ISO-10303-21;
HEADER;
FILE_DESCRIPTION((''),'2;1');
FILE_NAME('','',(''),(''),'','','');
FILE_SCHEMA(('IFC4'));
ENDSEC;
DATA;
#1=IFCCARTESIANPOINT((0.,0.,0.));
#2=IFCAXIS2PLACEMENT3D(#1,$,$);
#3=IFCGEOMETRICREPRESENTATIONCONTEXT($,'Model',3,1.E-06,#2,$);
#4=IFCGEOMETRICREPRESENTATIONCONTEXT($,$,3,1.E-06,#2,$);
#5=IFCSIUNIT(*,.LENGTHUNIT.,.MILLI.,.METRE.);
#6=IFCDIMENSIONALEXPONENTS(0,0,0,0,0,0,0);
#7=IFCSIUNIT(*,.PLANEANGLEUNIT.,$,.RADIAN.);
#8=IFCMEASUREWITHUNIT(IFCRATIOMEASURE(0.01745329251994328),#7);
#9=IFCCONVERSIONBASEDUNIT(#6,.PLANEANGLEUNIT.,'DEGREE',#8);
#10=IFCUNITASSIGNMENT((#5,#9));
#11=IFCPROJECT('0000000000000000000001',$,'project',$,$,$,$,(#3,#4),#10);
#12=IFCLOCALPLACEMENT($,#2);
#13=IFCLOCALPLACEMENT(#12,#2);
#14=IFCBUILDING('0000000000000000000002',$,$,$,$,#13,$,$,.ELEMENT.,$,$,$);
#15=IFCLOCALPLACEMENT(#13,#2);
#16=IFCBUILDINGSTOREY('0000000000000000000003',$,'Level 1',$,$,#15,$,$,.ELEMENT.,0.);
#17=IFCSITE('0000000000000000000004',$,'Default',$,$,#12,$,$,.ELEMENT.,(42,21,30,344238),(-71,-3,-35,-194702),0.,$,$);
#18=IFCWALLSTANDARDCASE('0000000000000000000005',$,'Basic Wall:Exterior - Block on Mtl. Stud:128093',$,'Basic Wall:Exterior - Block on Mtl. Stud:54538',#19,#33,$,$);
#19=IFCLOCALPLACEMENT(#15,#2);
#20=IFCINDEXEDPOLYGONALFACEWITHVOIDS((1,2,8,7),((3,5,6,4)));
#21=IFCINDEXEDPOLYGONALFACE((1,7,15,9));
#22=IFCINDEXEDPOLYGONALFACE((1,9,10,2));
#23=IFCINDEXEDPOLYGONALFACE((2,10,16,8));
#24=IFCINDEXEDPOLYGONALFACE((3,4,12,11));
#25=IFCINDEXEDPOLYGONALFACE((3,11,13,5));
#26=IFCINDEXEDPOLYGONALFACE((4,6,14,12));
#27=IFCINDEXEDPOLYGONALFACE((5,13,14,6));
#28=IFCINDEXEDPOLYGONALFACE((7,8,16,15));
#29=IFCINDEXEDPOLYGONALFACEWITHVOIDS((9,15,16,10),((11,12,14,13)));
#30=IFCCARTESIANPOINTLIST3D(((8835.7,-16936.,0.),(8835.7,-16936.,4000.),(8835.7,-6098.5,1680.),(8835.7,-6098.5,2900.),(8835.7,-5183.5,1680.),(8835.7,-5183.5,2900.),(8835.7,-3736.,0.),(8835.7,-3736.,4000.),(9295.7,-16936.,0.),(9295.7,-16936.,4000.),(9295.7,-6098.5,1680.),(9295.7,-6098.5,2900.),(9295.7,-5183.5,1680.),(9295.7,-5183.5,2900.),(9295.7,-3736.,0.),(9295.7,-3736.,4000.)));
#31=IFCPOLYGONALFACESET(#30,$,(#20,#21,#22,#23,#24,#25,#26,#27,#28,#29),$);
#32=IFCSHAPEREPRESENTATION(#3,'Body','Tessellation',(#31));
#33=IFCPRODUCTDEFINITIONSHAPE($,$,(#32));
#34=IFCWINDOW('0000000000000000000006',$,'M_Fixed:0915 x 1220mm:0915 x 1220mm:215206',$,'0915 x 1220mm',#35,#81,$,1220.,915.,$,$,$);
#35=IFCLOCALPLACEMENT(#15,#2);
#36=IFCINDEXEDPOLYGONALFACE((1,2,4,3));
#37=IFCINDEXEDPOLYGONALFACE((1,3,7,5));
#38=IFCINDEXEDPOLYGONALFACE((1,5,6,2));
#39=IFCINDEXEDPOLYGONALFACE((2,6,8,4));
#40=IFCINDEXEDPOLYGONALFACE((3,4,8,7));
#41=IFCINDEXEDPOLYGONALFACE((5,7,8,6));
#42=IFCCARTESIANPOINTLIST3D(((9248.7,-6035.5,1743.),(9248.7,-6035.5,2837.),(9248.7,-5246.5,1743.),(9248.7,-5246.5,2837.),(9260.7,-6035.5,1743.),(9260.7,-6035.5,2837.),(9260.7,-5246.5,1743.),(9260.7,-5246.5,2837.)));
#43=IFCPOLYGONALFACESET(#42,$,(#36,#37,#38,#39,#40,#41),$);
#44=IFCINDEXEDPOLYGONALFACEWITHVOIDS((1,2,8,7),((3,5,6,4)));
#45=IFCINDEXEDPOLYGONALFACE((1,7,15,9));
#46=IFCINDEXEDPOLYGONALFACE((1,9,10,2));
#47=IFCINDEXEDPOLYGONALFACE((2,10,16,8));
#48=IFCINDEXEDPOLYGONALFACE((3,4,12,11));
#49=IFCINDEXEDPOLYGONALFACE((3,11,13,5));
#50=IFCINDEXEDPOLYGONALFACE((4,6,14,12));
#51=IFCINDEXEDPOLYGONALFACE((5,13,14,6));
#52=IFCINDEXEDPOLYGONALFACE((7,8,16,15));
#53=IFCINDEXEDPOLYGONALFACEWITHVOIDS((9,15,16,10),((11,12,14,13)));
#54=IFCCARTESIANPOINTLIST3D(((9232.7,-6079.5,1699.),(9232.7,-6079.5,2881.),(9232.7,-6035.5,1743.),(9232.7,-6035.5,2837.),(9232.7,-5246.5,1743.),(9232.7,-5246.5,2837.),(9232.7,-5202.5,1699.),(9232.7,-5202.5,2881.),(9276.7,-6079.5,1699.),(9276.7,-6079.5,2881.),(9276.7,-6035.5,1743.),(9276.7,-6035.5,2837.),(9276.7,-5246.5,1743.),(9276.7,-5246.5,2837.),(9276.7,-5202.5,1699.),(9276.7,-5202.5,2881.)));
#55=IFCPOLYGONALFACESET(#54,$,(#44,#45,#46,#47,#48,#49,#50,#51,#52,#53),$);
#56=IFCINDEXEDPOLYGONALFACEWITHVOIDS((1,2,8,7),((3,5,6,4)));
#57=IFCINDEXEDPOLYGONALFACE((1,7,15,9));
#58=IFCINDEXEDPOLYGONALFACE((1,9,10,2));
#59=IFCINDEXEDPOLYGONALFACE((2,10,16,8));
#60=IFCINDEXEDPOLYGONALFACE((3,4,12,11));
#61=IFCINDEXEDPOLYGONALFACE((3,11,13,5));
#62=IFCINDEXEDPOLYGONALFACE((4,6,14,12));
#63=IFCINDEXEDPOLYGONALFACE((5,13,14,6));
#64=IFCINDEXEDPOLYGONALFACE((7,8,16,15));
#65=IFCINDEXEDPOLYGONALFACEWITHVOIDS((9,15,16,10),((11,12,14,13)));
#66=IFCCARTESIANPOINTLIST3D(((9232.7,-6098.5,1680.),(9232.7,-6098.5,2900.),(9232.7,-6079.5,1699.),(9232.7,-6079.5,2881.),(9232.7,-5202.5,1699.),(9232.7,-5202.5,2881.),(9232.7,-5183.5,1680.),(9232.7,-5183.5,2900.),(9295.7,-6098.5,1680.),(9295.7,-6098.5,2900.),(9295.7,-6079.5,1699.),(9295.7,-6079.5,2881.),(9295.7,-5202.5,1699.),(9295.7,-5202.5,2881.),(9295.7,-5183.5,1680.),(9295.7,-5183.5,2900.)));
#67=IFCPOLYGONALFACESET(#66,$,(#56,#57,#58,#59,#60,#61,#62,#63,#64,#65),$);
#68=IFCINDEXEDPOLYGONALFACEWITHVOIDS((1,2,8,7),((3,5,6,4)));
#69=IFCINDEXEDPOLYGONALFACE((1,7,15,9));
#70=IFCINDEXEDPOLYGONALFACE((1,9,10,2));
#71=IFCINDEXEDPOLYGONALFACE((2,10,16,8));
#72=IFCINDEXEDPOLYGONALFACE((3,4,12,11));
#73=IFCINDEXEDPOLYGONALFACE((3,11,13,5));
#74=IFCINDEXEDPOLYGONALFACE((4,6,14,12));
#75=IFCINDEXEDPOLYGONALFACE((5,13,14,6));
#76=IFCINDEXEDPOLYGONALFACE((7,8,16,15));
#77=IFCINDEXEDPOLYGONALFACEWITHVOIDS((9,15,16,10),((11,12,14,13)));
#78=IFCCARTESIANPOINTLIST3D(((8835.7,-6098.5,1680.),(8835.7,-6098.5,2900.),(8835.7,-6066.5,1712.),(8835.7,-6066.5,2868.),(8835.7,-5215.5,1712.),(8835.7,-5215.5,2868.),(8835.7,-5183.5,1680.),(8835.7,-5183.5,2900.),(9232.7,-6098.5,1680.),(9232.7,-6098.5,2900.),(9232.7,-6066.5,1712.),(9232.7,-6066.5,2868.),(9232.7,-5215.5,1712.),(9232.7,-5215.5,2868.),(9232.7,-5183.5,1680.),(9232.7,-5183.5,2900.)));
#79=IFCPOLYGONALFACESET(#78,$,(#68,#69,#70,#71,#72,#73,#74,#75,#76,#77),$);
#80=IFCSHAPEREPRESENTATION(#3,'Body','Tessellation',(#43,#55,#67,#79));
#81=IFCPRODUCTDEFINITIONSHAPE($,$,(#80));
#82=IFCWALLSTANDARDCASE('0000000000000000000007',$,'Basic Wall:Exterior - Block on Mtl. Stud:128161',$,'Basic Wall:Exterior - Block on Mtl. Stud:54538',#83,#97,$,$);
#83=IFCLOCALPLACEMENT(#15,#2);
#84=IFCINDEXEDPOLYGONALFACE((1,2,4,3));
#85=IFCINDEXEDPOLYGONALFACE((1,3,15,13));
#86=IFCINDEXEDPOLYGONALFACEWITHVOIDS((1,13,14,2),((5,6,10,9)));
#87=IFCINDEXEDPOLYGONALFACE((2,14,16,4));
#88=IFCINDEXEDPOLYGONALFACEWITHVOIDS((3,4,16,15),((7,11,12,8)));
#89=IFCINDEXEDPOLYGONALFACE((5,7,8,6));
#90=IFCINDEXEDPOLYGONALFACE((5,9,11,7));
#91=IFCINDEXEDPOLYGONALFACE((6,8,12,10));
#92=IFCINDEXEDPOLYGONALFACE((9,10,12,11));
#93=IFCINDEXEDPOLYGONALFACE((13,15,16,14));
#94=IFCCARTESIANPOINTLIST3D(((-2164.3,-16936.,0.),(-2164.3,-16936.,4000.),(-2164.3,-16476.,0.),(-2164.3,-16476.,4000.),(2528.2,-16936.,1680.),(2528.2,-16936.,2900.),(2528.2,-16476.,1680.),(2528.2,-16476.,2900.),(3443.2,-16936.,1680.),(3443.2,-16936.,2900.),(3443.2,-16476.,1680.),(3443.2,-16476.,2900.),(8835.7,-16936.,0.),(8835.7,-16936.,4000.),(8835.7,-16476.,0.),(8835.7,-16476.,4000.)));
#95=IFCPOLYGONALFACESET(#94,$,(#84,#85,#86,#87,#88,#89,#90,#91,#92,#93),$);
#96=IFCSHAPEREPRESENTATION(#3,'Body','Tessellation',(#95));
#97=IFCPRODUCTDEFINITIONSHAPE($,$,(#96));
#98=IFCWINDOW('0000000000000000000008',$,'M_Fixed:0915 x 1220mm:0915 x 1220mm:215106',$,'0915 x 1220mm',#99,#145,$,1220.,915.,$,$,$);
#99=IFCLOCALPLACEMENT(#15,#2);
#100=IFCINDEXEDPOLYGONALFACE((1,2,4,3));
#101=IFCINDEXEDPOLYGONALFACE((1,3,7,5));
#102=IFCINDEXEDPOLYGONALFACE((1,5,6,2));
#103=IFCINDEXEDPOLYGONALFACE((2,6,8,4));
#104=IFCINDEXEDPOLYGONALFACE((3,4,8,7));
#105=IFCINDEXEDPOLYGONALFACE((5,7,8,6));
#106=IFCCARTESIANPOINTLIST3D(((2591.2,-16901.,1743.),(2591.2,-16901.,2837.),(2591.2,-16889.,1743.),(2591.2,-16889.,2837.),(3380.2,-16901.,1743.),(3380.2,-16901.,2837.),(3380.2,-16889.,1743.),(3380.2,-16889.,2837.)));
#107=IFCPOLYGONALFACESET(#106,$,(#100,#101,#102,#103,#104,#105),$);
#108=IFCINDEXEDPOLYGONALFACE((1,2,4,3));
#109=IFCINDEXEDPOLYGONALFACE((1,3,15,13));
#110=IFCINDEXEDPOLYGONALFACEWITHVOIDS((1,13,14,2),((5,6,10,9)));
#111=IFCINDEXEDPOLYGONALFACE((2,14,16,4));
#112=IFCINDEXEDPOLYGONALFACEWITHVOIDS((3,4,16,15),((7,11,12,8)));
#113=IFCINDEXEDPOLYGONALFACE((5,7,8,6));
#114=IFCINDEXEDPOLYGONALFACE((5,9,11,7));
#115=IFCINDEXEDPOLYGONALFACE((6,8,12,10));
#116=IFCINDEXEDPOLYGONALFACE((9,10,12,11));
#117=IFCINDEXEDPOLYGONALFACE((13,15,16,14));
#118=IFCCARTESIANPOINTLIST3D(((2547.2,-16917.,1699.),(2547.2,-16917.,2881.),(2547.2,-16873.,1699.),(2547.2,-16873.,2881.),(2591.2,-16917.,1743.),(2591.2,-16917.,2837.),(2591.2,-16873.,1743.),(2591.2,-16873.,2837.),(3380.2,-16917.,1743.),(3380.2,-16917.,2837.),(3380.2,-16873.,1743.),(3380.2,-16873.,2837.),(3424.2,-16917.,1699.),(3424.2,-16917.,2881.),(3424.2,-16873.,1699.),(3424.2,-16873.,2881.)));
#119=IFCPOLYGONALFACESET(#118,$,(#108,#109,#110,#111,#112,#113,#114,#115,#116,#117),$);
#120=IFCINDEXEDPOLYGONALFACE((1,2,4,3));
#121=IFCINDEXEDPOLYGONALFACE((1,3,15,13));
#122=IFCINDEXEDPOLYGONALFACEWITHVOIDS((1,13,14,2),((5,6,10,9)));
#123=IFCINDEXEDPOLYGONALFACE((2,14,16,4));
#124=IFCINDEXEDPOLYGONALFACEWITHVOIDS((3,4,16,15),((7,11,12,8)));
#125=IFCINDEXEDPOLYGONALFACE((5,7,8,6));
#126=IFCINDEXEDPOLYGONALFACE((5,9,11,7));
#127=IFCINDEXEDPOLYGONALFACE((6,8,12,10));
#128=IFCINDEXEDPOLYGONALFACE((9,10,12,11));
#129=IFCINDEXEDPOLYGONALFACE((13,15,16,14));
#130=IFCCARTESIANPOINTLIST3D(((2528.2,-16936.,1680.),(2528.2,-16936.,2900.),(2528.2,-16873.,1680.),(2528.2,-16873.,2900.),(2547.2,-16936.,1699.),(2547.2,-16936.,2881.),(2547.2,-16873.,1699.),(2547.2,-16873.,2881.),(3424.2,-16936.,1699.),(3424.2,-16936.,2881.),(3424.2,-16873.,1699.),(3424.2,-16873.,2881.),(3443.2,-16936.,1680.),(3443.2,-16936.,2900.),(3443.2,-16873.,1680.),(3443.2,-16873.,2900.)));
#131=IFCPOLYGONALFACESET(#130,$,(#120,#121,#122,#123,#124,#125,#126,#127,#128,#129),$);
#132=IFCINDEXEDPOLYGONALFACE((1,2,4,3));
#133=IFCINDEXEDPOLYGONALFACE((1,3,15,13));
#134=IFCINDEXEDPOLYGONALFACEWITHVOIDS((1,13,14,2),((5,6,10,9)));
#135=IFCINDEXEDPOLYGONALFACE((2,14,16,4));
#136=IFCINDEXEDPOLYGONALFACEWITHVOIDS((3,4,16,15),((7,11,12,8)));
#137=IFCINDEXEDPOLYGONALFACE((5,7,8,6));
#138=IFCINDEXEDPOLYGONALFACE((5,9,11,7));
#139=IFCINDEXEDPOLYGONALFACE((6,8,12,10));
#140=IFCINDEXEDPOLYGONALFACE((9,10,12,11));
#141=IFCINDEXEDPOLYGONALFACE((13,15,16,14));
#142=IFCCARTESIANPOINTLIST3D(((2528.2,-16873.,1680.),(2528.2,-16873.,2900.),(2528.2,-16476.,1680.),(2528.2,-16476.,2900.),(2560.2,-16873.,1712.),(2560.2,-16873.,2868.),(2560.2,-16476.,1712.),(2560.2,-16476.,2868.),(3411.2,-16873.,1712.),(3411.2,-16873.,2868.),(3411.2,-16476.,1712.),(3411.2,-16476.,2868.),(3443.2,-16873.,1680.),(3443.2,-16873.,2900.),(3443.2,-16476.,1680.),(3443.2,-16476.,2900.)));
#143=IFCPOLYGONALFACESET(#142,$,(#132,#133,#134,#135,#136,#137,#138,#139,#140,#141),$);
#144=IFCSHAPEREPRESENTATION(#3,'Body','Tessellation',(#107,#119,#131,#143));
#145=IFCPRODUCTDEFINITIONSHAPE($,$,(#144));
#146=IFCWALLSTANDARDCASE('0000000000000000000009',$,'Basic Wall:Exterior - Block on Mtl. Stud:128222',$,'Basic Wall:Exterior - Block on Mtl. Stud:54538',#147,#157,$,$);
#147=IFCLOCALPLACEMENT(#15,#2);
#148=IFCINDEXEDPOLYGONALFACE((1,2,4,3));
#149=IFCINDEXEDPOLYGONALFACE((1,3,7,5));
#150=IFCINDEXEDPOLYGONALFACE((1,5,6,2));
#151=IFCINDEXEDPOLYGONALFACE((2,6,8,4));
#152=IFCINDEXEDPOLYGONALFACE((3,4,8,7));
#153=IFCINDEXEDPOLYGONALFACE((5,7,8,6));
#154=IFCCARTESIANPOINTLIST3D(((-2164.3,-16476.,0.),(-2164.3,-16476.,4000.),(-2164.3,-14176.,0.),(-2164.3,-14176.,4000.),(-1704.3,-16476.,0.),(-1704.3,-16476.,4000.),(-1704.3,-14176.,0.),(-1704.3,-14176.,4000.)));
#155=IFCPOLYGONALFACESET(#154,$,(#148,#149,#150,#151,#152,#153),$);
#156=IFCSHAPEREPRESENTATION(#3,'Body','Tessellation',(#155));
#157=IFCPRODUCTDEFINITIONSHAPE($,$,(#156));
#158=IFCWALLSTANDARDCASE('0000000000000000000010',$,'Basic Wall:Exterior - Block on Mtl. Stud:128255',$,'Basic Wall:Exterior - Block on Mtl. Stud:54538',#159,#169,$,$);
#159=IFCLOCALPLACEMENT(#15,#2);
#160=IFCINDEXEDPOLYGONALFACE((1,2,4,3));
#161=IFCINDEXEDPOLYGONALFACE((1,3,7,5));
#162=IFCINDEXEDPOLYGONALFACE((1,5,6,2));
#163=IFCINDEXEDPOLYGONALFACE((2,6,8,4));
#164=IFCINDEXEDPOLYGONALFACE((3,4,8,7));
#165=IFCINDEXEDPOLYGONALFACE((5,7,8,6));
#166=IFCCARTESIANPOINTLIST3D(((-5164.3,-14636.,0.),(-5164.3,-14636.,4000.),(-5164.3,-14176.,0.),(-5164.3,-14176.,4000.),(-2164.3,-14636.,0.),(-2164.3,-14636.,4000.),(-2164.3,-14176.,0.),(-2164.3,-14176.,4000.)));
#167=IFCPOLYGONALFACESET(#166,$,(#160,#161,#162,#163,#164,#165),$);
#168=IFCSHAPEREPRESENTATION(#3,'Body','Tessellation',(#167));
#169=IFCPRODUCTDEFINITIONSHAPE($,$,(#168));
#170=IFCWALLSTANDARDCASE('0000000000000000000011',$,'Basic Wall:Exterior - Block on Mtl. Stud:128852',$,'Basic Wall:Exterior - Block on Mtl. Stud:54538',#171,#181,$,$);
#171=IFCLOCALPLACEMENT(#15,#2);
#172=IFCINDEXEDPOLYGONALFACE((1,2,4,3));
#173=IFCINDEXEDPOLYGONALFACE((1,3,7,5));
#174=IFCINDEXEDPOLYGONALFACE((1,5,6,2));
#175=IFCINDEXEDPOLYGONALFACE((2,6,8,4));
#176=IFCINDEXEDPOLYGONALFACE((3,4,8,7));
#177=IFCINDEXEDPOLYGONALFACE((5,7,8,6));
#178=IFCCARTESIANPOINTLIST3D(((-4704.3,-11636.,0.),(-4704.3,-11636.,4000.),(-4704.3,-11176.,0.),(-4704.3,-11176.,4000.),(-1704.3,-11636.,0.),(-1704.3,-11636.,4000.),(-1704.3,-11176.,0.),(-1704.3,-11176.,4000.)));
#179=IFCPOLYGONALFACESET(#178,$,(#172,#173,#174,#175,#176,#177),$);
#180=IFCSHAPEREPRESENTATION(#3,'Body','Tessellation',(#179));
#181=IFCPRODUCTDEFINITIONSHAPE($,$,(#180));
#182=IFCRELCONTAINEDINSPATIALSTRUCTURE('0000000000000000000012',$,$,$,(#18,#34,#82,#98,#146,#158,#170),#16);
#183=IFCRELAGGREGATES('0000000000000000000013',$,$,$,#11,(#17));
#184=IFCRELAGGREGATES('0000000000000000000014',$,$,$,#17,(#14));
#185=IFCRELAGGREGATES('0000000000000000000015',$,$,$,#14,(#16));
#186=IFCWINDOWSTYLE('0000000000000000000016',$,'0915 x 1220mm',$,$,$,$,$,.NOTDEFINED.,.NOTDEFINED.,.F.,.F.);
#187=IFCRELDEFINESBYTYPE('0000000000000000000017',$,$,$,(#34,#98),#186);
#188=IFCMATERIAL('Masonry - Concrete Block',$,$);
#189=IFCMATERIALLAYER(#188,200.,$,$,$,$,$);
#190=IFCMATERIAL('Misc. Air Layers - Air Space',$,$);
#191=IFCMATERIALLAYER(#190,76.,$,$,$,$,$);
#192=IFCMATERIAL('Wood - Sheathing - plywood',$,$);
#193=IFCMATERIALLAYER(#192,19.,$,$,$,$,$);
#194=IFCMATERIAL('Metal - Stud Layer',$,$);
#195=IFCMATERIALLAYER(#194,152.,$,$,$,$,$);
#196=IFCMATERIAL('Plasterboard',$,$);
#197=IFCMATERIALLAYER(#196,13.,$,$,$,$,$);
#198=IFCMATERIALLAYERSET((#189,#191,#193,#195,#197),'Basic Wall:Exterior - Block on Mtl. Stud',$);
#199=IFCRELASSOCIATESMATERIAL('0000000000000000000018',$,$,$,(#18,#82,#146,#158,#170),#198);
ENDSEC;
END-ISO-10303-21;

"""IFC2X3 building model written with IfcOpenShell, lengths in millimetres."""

from ifc_helpers import new_model, entity, si_unit, converted_unit, frame, frame_2d, origin, origin_2d_with_axis, place, context, project, spatial, polyline, rectangle, outline, extrude, source, transform, mapped, material, layer, layer_set, layer_usage, type_object, type_shapes, element, fill, save


model = new_model("IFC2X3")

# Units and contexts
model_context = context("Model", 3, precision=1e-06, world=origin())
context_of_model = context(None, 3, precision=1e-06, world=origin())
ifc_project = project(units=[si_unit("LENGTHUNIT", "METRE", prefix="MILLI"), converted_unit("PLANEANGLEUNIT", "DEGREE", entity("IfcRatioMeasure", 0.01745329251994328), si_unit("PLANEANGLEUNIT", "RADIAN"), dimensions=[0, 0, 0, 0, 0, 0, 0])], contexts=[model_context, context_of_model])

# Site, building, storey
site_placement = place(None, origin())
site = spatial("IfcSite", under=ifc_project, at=site_placement, Name="Default", CompositionType="ELEMENT", RefLatitude=(42, 21, 30, 344238), RefLongitude=(-71, -3, -35, -194702), RefElevation=0.0)
building_placement = place(site_placement, origin())
building = spatial("IfcBuilding", under=site, at=building_placement, CompositionType="ELEMENT")
storey_placement = place(building_placement, origin())
storey = spatial("IfcBuildingStorey", under=building, at=storey_placement, Name="Level 1", CompositionType="ELEMENT", Elevation=0.0)

# Walls, openings, windows
ifc_material_1 = material(Name="Masonry - Concrete Block")
ifc_layer_1 = layer(ifc_material_1, 200.0)
ifc_material_2 = material(Name="Misc. Air Layers - Air Space")
ifc_layer_2 = layer(ifc_material_2, 76.0)
ifc_material_3 = material(Name="Wood - Sheathing - plywood")
ifc_layer_3 = layer(ifc_material_3, 19.0)
ifc_material_4 = material(Name="Metal - Stud Layer")
ifc_layer_4 = layer(ifc_material_4, 152.0)
ifc_material_5 = material(Name="Plasterboard")
ifc_layer_5 = layer(ifc_material_5, 13.0)
ifc_layer_set_1 = layer_set([ifc_layer_1, ifc_layer_2, ifc_layer_3, ifc_layer_4, ifc_layer_5], Name="Basic Wall:Exterior - Block on Mtl. Stud")
ifc_layer_usage_1 = layer_usage(ifc_layer_set_1, "AXIS2", "NEGATIVE", 230.0)
wall_1_placement = place(storey_placement, frame((9065.7, -3736.0, 0.0), z_axis=(0.0, 0.0, 1.0), x_axis=(0.0, -1.0, 0.0)))
wall_1 = element("IfcWallStandardCase", 1, at=wall_1_placement, inside=storey, material=ifc_layer_usage_1, Name="Basic Wall:Exterior - Block on Mtl. Stud:128093", ObjectType="Basic Wall:Exterior - Block on Mtl. Stud:54538", context=model_context, shape_type="SweptSolid", body=[
    extrude(rectangle(XDim=13200.0, YDim=460.0, at=frame_2d((6600.0, 0.0), x_axis=(-1.0, 0.0))), origin(), (0.0, 0.0, 1.0), 4000.0),
])
opening_1_placement = place(wall_1_placement, frame((1447.5, -230.0, 1680.0)))
opening_1 = element("IfcOpeningElement", 2, at=opening_1_placement, cuts=wall_1, ObjectType="Opening", context=model_context, shape_type="SweptSolid", body=[
    extrude(rectangle(XDim=1220.0, YDim=915.0, at=frame_2d((610.0, 457.5), x_axis=(1.0, 0.0))), frame((0.0, 0.0, 0.0), z_axis=(0.0, 1.0, 0.0), x_axis=(0.0, 0.0, 1.0)), (0.0, 0.0, 1.0), 460.0),
])
window_style_1 = type_object("IfcWindowStyle", Name="0915 x 1220mm", ConstructionType="NOTDEFINED", OperationType="NOTDEFINED", ParameterTakesPrecedence=False, Sizeable=False)
shared_shape_1 = source(origin(), model_context, "Body", "SweptSolid", [
    extrude(rectangle(XDim=12.0, YDim=789.0, at=origin_2d_with_axis()), frame((457.5, 419.0, 63.0), z_axis=(0.0, 0.0, 1.0), x_axis=(0.0, -1.0, 0.0)), (0.0, 0.0, 1.0), 1094.0),
    extrude(outline(polyline([(-438.5, -591.0), (438.5, -591.0), (438.5, 591.0), (-438.5, 591.0), (-438.5, -591.0)]), holes=[polyline([(-394.5, -547.0), (-394.5, 547.0), (394.5, 547.0), (394.5, -547.0), (-394.5, -547.0)])]), frame((457.5, 397.0, 610.0), z_axis=(0.0, 1.0, 0.0), x_axis=(1.0, 0.0, 0.0)), (0.0, 0.0, 1.0), 44.0),
    extrude(outline(polyline([(-457.5, -610.0), (457.5, -610.0), (457.5, 610.0), (-457.5, 610.0), (-457.5, -610.0)]), holes=[polyline([(-438.5, -591.0), (-438.5, 591.0), (438.5, 591.0), (438.5, -591.0), (-438.5, -591.0)])]), frame((457.5, 397.0, 610.0), z_axis=(0.0, 1.0, 0.0), x_axis=(1.0, 0.0, 0.0)), (0.0, 0.0, 1.0), 63.0),
    extrude(outline(polyline([(-457.5, -610.0), (457.5, -610.0), (457.5, 610.0), (-457.5, 610.0), (-457.5, -610.0)]), holes=[polyline([(-425.5, -578.0), (-425.5, 578.0), (425.5, 578.0), (425.5, -578.0), (-425.5, -578.0)])]), frame((457.5, 0.0, 610.0), z_axis=(0.0, 1.0, 0.0), x_axis=(1.0, 0.0, 0.0)), (0.0, 0.0, 1.0), 397.0),
])
type_shapes(window_style_1, [shared_shape_1])
window_1_placement = place(opening_1_placement, origin())
window_1 = element("IfcWindow", 3, at=window_1_placement, inside=storey, type_object=window_style_1, Name="M_Fixed:0915 x 1220mm:0915 x 1220mm:215206", ObjectType="0915 x 1220mm", OverallHeight=1220.0, OverallWidth=915.0, context=model_context, shape_type="MappedRepresentation", body=[
    mapped(shared_shape_1, transform((0.0, 0.0, 0.0), scale=1.0)),
])
fill(opening_1, window_1)
ifc_layer_usage_2 = layer_usage(ifc_layer_set_1, "AXIS2", "NEGATIVE", 230.0)
wall_2_placement = place(storey_placement, frame((8835.7, -16706.0, 0.0), z_axis=(0.0, 0.0, 1.0), x_axis=(-1.0, 0.0, 0.0)))
wall_2 = element("IfcWallStandardCase", 4, at=wall_2_placement, inside=storey, material=ifc_layer_usage_2, Name="Basic Wall:Exterior - Block on Mtl. Stud:128161", ObjectType="Basic Wall:Exterior - Block on Mtl. Stud:54538", context=model_context, shape_type="SweptSolid", body=[
    extrude(rectangle(XDim=11000.0, YDim=460.0, at=frame_2d((5500.0, 0.0), x_axis=(-1.0, 0.0))), origin(), (0.0, 0.0, 1.0), 4000.0),
])
opening_2_placement = place(wall_2_placement, frame((5392.5, -230.0, 1680.0)))
opening_2 = element("IfcOpeningElement", 5, at=opening_2_placement, cuts=wall_2, ObjectType="Opening", context=model_context, shape_type="SweptSolid", body=[
    extrude(rectangle(XDim=1220.0, YDim=915.0, at=frame_2d((610.0, 457.5), x_axis=(1.0, 0.0))), frame((0.0, 0.0, 0.0), z_axis=(0.0, 1.0, 0.0), x_axis=(0.0, 0.0, 1.0)), (0.0, 0.0, 1.0), 460.0),
])
window_2_placement = place(opening_2_placement, origin())
window_2 = element("IfcWindow", 6, at=window_2_placement, inside=storey, type_object=window_style_1, Name="M_Fixed:0915 x 1220mm:0915 x 1220mm:215106", ObjectType="0915 x 1220mm", OverallHeight=1220.0, OverallWidth=915.0, context=model_context, shape_type="MappedRepresentation", body=[
    mapped(shared_shape_1, transform((0.0, 0.0, 0.0), scale=1.0)),
])
fill(opening_2, window_2)

# Walls
ifc_layer_usage_3 = layer_usage(ifc_layer_set_1, "AXIS2", "NEGATIVE", 230.0)
wall_3_placement = place(storey_placement, frame((-1934.3, -16476.0, 0.0), z_axis=(0.0, 0.0, 1.0), x_axis=(0.0, 1.0, 0.0)))
element("IfcWallStandardCase", 7, at=wall_3_placement, inside=storey, material=ifc_layer_usage_3, Name="Basic Wall:Exterior - Block on Mtl. Stud:128222", ObjectType="Basic Wall:Exterior - Block on Mtl. Stud:54538", context=model_context, shape_type="SweptSolid", body=[
    extrude(rectangle(XDim=2300.0, YDim=460.0, at=frame_2d((1150.0, 0.0), x_axis=(-1.0, 0.0))), origin(), (0.0, 0.0, 1.0), 4000.0),
])
ifc_layer_usage_4 = layer_usage(ifc_layer_set_1, "AXIS2", "NEGATIVE", 230.0)
wall_4_placement = place(storey_placement, frame((-2164.3, -14406.0, 0.0), z_axis=(0.0, 0.0, 1.0), x_axis=(-1.0, 0.0, 0.0)))
element("IfcWallStandardCase", 8, at=wall_4_placement, inside=storey, material=ifc_layer_usage_4, Name="Basic Wall:Exterior - Block on Mtl. Stud:128255", ObjectType="Basic Wall:Exterior - Block on Mtl. Stud:54538", context=model_context, shape_type="SweptSolid", body=[
    extrude(rectangle(XDim=3000.0, YDim=460.0, at=frame_2d((1500.0, 0.0), x_axis=(-1.0, 0.0))), origin(), (0.0, 0.0, 1.0), 4000.0),
])
ifc_layer_usage_5 = layer_usage(ifc_layer_set_1, "AXIS2", "NEGATIVE", 230.0)
wall_5_placement = place(storey_placement, frame((-4704.3, -11406.0, 0.0)))
element("IfcWallStandardCase", 9, at=wall_5_placement, inside=storey, material=ifc_layer_usage_5, Name="Basic Wall:Exterior - Block on Mtl. Stud:128852", ObjectType="Basic Wall:Exterior - Block on Mtl. Stud:54538", context=model_context, shape_type="SweptSolid", body=[
    extrude(rectangle(XDim=3000.0, YDim=460.0, at=frame_2d((1500.0, 0.0), x_axis=(-1.0, 0.0))), origin(), (0.0, 0.0, 1.0), 4000.0),
])

save(model, "model.ifc")
